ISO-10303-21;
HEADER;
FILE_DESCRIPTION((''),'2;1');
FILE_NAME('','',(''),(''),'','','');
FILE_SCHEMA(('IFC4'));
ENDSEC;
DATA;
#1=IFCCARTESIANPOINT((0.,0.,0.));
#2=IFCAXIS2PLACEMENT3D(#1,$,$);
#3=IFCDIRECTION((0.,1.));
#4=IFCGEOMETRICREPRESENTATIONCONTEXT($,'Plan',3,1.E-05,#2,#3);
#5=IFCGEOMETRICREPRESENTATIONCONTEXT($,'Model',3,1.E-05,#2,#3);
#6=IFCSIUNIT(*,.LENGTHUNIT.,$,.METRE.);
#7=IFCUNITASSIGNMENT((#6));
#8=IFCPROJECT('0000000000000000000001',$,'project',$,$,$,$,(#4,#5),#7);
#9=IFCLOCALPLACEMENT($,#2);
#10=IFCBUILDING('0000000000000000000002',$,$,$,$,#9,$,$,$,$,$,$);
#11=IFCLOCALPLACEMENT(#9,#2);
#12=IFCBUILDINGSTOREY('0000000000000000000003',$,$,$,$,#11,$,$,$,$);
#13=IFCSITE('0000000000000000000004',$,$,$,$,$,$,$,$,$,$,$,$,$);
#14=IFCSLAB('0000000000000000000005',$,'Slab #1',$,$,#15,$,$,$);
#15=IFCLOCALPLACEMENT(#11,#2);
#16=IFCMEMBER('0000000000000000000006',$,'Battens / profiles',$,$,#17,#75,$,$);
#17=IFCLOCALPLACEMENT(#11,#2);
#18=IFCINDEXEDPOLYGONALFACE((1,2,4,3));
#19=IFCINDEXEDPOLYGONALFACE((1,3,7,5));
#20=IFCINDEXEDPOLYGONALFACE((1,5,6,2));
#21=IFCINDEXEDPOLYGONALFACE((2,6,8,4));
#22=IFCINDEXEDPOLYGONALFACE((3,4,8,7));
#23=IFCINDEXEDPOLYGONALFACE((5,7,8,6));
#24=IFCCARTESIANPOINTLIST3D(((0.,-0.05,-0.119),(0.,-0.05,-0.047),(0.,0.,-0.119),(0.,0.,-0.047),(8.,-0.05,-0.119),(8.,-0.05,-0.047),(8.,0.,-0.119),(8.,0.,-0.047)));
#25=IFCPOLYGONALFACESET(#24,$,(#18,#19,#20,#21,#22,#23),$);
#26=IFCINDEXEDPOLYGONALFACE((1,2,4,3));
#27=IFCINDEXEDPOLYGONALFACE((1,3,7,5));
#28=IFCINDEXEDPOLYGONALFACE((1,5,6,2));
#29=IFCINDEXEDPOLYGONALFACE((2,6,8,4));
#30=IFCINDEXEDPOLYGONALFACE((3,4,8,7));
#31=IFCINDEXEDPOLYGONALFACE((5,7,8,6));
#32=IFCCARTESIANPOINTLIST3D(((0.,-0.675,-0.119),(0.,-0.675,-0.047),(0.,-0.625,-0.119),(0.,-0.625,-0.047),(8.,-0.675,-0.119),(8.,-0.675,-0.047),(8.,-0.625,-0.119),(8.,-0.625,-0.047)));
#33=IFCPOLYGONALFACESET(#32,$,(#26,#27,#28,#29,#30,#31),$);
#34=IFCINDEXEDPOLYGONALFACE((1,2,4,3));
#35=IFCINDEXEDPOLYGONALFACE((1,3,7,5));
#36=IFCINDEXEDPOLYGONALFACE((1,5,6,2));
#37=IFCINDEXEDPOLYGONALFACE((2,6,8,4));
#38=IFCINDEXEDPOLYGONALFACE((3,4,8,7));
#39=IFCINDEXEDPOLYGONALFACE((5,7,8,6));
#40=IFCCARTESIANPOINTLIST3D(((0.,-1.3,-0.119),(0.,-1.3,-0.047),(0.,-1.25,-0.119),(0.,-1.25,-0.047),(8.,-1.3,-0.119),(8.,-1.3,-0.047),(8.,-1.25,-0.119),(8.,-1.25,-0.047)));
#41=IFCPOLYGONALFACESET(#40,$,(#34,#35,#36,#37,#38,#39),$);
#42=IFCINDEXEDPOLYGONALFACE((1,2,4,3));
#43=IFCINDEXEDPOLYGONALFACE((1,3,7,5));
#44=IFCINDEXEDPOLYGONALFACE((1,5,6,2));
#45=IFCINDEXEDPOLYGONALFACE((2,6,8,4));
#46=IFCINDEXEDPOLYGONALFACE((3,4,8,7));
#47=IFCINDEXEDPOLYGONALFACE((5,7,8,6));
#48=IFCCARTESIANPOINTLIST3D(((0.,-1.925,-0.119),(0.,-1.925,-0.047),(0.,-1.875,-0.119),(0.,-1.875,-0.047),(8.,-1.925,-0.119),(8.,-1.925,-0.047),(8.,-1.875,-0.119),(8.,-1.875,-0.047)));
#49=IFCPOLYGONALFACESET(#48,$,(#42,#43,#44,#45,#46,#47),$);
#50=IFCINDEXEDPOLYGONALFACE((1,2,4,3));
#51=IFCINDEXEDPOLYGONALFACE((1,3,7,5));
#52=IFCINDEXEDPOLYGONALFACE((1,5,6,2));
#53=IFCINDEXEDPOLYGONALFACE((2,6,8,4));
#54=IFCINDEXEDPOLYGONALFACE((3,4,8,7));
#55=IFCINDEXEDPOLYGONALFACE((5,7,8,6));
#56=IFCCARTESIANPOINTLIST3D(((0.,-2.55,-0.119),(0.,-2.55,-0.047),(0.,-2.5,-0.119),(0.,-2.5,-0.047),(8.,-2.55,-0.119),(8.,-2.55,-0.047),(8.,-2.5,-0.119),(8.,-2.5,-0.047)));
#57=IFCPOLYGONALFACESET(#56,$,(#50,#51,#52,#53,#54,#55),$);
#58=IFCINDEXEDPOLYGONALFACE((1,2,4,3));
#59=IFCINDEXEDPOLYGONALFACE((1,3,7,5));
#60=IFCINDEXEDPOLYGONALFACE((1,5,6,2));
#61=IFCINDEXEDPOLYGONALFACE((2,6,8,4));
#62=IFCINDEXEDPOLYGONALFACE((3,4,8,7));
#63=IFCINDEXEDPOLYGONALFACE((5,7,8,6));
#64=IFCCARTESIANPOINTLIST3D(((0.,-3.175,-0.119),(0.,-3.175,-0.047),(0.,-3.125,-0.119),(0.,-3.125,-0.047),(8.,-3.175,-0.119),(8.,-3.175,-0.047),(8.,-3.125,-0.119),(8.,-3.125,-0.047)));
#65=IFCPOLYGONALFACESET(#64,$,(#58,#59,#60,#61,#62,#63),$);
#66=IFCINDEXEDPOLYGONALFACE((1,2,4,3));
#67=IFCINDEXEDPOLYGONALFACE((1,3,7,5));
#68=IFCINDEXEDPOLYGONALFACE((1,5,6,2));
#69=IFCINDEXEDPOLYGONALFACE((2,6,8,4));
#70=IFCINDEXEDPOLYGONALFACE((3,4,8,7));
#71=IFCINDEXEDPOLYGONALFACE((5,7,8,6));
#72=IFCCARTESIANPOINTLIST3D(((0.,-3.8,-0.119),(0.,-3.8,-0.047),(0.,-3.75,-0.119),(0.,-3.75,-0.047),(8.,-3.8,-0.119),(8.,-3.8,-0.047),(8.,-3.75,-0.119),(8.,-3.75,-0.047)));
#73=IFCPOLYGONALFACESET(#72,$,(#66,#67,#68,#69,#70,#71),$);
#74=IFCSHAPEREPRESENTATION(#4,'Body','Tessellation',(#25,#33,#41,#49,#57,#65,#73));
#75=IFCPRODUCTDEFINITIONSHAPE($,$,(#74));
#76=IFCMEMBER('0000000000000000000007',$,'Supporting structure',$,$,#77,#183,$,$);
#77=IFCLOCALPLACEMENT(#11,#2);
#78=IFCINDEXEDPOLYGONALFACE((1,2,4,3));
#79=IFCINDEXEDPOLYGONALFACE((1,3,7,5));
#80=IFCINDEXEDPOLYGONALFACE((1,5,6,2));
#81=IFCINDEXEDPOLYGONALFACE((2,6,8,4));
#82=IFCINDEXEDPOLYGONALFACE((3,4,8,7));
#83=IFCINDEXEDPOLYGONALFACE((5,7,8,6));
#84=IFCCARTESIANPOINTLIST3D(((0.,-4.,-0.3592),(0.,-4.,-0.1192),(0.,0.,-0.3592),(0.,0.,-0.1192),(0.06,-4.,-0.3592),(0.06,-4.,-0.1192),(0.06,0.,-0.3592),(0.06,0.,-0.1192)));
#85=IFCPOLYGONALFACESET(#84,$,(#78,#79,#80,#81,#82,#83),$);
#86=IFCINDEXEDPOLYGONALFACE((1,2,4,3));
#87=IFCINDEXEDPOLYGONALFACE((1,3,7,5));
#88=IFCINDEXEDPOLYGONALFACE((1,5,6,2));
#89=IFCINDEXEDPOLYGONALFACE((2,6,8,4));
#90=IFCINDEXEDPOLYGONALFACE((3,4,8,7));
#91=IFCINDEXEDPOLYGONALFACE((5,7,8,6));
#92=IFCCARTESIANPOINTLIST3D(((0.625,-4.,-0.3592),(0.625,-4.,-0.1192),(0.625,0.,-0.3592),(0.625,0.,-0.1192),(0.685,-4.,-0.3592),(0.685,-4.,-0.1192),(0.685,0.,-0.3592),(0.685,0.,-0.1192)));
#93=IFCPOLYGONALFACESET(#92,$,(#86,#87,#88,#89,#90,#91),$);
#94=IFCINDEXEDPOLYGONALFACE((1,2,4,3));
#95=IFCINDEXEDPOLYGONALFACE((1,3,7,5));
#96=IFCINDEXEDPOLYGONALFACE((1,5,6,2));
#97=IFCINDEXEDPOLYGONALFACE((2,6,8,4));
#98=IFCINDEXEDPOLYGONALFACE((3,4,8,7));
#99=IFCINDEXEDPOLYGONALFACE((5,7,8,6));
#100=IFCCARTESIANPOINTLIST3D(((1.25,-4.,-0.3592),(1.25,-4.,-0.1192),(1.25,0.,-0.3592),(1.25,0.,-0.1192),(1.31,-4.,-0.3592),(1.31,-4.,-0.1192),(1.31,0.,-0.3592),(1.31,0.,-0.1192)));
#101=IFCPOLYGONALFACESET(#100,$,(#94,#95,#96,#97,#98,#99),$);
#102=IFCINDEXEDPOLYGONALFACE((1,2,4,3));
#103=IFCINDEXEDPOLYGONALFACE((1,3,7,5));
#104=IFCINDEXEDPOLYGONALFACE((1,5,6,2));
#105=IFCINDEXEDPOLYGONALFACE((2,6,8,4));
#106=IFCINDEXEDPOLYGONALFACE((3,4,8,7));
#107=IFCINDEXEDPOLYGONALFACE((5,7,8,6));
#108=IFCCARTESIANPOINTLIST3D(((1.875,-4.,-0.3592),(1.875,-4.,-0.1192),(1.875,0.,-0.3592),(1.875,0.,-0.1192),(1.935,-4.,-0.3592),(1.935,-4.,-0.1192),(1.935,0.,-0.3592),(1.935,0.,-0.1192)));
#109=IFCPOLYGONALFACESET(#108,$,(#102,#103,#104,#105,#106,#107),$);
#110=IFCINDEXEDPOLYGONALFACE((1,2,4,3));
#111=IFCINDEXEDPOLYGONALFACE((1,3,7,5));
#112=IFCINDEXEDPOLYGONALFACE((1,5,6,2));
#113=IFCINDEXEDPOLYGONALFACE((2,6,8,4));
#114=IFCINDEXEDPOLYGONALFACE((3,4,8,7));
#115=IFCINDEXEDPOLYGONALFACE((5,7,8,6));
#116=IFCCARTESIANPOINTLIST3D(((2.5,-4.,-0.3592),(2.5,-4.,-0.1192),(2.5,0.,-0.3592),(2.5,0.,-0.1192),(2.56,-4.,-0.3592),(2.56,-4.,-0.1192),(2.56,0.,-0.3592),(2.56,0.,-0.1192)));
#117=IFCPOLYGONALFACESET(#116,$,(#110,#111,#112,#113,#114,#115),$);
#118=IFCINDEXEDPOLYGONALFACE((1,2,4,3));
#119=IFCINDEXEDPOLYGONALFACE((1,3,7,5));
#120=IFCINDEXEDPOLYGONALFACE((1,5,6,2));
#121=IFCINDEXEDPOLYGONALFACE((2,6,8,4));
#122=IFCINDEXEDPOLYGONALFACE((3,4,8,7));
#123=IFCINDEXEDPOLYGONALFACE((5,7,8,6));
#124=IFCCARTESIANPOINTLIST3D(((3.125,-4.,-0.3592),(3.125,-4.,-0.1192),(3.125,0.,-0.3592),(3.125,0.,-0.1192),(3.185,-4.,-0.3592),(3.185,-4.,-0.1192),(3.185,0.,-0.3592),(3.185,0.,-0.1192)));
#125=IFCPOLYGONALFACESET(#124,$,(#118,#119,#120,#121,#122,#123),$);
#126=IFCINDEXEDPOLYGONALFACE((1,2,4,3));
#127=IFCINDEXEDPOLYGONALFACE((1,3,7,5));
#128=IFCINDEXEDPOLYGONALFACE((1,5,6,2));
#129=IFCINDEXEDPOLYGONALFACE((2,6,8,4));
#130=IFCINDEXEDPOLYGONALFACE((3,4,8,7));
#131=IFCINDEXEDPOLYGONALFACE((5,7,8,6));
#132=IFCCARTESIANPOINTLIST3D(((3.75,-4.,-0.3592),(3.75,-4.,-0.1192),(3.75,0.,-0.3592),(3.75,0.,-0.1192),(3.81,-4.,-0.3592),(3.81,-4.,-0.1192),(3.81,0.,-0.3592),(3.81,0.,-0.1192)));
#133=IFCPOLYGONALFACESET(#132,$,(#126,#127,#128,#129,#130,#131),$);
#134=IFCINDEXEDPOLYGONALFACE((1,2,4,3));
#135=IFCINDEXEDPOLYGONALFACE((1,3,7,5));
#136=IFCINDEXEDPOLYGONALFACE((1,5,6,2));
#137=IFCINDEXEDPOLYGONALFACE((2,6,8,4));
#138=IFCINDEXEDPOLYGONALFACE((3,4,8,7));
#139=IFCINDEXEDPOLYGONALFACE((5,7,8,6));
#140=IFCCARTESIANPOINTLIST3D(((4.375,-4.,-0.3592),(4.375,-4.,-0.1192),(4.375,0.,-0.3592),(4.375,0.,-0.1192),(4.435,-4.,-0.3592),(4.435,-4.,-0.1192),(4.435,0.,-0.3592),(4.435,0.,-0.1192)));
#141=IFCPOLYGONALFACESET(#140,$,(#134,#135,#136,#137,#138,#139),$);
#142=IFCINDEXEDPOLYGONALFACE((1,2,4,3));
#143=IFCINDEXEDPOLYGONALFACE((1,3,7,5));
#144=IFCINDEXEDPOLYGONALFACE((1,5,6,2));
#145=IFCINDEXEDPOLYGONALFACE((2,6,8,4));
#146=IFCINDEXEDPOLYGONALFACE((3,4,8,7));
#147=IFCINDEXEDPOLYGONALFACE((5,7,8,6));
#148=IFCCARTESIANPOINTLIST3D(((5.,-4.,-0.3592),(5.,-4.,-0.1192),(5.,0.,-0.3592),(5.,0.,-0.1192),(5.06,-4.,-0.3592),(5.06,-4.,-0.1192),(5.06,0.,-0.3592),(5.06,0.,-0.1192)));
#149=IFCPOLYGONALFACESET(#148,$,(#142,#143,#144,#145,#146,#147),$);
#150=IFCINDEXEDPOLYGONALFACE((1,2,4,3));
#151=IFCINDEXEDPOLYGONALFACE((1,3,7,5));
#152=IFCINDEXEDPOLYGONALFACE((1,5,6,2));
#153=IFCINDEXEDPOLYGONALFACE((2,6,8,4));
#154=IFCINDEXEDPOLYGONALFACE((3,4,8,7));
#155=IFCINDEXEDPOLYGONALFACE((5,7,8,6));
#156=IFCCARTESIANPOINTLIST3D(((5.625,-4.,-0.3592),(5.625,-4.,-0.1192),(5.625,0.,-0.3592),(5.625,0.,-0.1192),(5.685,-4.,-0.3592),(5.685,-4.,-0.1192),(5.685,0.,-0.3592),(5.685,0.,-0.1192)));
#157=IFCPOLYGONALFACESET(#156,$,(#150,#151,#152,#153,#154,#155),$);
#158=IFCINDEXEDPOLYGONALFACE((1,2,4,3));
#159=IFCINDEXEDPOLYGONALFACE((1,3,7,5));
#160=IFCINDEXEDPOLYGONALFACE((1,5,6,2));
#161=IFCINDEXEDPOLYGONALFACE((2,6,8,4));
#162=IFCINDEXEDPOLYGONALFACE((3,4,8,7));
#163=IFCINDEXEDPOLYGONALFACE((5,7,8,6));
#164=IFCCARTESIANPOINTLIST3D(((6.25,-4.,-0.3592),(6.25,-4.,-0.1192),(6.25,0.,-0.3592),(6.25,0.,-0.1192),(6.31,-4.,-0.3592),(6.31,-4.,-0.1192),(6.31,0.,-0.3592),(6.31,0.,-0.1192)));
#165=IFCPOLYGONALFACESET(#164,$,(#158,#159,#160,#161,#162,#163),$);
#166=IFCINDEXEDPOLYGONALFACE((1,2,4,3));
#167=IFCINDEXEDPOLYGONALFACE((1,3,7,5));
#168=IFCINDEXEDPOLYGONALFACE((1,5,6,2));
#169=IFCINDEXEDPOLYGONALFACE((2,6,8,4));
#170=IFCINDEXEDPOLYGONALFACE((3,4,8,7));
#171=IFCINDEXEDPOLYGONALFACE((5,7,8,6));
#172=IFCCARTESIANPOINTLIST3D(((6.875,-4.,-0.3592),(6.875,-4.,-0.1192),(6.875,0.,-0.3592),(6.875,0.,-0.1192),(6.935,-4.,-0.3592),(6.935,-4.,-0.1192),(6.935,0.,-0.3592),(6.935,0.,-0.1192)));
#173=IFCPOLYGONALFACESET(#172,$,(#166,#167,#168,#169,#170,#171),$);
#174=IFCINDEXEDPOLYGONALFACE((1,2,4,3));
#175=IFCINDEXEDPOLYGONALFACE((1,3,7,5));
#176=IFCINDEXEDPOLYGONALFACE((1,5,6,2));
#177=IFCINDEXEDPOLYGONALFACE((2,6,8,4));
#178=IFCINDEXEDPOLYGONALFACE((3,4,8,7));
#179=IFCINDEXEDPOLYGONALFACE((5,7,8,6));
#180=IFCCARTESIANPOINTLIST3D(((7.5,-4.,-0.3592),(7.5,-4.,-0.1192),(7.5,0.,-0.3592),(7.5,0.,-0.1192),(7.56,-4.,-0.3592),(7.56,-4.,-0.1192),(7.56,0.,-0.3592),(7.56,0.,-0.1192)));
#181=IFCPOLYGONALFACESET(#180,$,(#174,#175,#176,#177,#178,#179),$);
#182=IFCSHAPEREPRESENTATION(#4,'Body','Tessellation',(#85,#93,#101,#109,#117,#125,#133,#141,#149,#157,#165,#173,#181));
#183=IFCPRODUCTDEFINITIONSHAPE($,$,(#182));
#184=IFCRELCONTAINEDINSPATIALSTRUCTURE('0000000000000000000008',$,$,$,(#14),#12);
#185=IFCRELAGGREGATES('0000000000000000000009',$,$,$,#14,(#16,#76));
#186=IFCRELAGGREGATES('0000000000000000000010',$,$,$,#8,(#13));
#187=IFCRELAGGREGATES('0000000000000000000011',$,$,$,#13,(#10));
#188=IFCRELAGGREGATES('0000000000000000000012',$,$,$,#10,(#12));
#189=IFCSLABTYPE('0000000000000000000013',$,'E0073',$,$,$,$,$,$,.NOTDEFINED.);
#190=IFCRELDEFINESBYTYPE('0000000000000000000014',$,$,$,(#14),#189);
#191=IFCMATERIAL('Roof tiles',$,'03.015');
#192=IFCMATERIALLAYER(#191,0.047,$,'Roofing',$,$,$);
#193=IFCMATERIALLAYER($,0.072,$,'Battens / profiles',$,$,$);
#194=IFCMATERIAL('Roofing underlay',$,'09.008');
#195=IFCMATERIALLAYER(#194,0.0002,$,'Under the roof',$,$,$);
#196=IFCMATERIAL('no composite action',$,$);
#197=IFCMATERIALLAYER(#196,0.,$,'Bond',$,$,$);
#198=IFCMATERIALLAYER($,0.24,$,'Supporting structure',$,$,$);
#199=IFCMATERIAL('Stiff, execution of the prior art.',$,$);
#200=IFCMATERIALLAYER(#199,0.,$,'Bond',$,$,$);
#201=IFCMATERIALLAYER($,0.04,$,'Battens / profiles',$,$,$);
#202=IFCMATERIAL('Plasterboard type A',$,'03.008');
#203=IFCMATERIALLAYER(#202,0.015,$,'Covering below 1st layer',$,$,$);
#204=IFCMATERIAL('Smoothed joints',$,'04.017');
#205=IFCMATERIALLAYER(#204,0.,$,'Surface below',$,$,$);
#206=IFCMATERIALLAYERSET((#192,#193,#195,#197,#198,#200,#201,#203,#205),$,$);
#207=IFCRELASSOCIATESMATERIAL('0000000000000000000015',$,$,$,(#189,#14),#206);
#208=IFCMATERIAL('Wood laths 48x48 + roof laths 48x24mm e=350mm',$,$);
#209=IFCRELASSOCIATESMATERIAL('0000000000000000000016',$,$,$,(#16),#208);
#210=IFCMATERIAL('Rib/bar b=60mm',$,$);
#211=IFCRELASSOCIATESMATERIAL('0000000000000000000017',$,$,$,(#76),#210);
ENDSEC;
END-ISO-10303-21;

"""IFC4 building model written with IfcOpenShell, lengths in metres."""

from ifc_helpers import new_model, si_unit, direction, frame, frame_2d, origin, place, context, project, spatial, rectangle, extrude, material, layer, layer_set, type_object, element, aggregate, save


model = new_model("IFC4")

# Units and contexts
plan_context = context("Plan", 3, precision=1e-05, world=origin(), true_north=direction((0.0, 1.0)))
model_context = context("Model", 3, precision=1e-05, world=origin(), true_north=direction((0.0, 1.0)))
ifc_project = project(units=[si_unit("LENGTHUNIT", "METRE")], contexts=[plan_context, model_context])

# Site, building, storey
site = spatial("IfcSite", under=ifc_project)
building_placement = place(None, origin())
building = spatial("IfcBuilding", under=site, at=building_placement)
storey_placement = place(building_placement, origin())
storey = spatial("IfcBuildingStorey", under=building, at=storey_placement)

# Slab, members
ifc_material_1 = material(Name="Roof tiles", Category="03.015")
ifc_layer_1 = layer(ifc_material_1, 0.047, Name="Roofing")
ifc_layer_2 = layer(None, 0.072, Name="Battens / profiles")
ifc_material_2 = material(Name="Roofing underlay", Category="09.008")
ifc_layer_3 = layer(ifc_material_2, 0.0002, Name="Under the roof")
ifc_material_3 = material(Name="no composite action")
ifc_layer_4 = layer(ifc_material_3, 0.0, Name="Bond")
ifc_layer_5 = layer(None, 0.24, Name="Supporting structure")
ifc_material_4 = material(Name="Stiff, execution of the prior art.")
ifc_layer_6 = layer(ifc_material_4, 0.0, Name="Bond")
ifc_layer_7 = layer(None, 0.04, Name="Battens / profiles")
ifc_material_5 = material(Name="Plasterboard type A", Category="03.008")
ifc_layer_8 = layer(ifc_material_5, 0.015, Name="Covering below 1st layer")
ifc_material_6 = material(Name="Smoothed joints", Category="04.017")
ifc_layer_9 = layer(ifc_material_6, 0.0, Name="Surface below")
ifc_layer_set = layer_set([ifc_layer_1, ifc_layer_2, ifc_layer_3, ifc_layer_4, ifc_layer_5, ifc_layer_6, ifc_layer_7, ifc_layer_8, ifc_layer_9])
slab_type = type_object("IfcSlabType", Name="E0073", PredefinedType="NOTDEFINED", material=ifc_layer_set)
slab_placement = place(None, frame((0.0, 0.0, 0.0), z_axis=(0.0, 0.0, -1.0), x_axis=(1.0, 0.0, 0.0)))
slab = element("IfcSlab", 1, at=slab_placement, inside=storey, type_object=slab_type, material=ifc_layer_set, Name="Slab #1")
ifc_material_7 = material(Name="Wood laths 48x48 + roof laths 48x24mm e=350mm")
member_1_placement = place(slab_placement, origin())
member_1 = element("IfcMember", 2, at=member_1_placement, material=ifc_material_7, Name="Battens / profiles", context=plan_context, shape_type="SweptSolid", body=[
    extrude(rectangle(XDim=0.05, YDim=0.072, at=frame_2d((0.025, 0.036), x_axis=(1.0, 0.0))), frame((0.0, 0.0, 0.047), z_axis=(1.0, 0.0, 0.0), x_axis=(0.0, 1.0, 0.0)), (0.0, 0.0, 1.0), 8.0),
    extrude(rectangle(XDim=0.05, YDim=0.072, at=frame_2d((0.025, 0.036), x_axis=(1.0, 0.0))), frame((0.0, 0.625, 0.047), z_axis=(1.0, 0.0, 0.0), x_axis=(0.0, 1.0, 0.0)), (0.0, 0.0, 1.0), 8.0),
    extrude(rectangle(XDim=0.05, YDim=0.072, at=frame_2d((0.025, 0.036), x_axis=(1.0, 0.0))), frame((0.0, 1.25, 0.047), z_axis=(1.0, 0.0, 0.0), x_axis=(0.0, 1.0, 0.0)), (0.0, 0.0, 1.0), 8.0),
    extrude(rectangle(XDim=0.05, YDim=0.072, at=frame_2d((0.025, 0.036), x_axis=(1.0, 0.0))), frame((0.0, 1.875, 0.047), z_axis=(1.0, 0.0, 0.0), x_axis=(0.0, 1.0, 0.0)), (0.0, 0.0, 1.0), 8.0),
    extrude(rectangle(XDim=0.05, YDim=0.072, at=frame_2d((0.025, 0.036), x_axis=(1.0, 0.0))), frame((0.0, 2.5, 0.047), z_axis=(1.0, 0.0, 0.0), x_axis=(0.0, 1.0, 0.0)), (0.0, 0.0, 1.0), 8.0),
    extrude(rectangle(XDim=0.05, YDim=0.072, at=frame_2d((0.025, 0.036), x_axis=(1.0, 0.0))), frame((0.0, 3.125, 0.047), z_axis=(1.0, 0.0, 0.0), x_axis=(0.0, 1.0, 0.0)), (0.0, 0.0, 1.0), 8.0),
    extrude(rectangle(XDim=0.05, YDim=0.072, at=frame_2d((0.025, 0.036), x_axis=(1.0, 0.0))), frame((0.0, 3.75, 0.047), z_axis=(1.0, 0.0, 0.0), x_axis=(0.0, 1.0, 0.0)), (0.0, 0.0, 1.0), 8.0),
])
ifc_material_8 = material(Name="Rib/bar b=60mm")
member_2_placement = place(slab_placement, origin())
member_2 = element("IfcMember", 3, at=member_2_placement, material=ifc_material_8, Name="Supporting structure", context=plan_context, shape_type="SweptSolid", body=[
    extrude(rectangle(XDim=0.06, YDim=0.24, at=frame_2d((0.03, 0.12), x_axis=(1.0, 0.0))), frame((0.0, 4.0, 0.1192), z_axis=(0.0, -1.0, 0.0), x_axis=(1.0, 0.0, 0.0)), (0.0, 0.0, 1.0), 4.0),
    extrude(rectangle(XDim=0.06, YDim=0.24, at=frame_2d((0.03, 0.12), x_axis=(1.0, 0.0))), frame((0.625, 4.0, 0.1192), z_axis=(0.0, -1.0, 0.0), x_axis=(1.0, 0.0, 0.0)), (0.0, 0.0, 1.0), 4.0),
    extrude(rectangle(XDim=0.06, YDim=0.24, at=frame_2d((0.03, 0.12), x_axis=(1.0, 0.0))), frame((1.25, 4.0, 0.1192), z_axis=(0.0, -1.0, 0.0), x_axis=(1.0, 0.0, 0.0)), (0.0, 0.0, 1.0), 4.0),
    extrude(rectangle(XDim=0.06, YDim=0.24, at=frame_2d((0.03, 0.12), x_axis=(1.0, 0.0))), frame((1.875, 4.0, 0.1192), z_axis=(0.0, -1.0, 0.0), x_axis=(1.0, 0.0, 0.0)), (0.0, 0.0, 1.0), 4.0),
    extrude(rectangle(XDim=0.06, YDim=0.24, at=frame_2d((0.03, 0.12), x_axis=(1.0, 0.0))), frame((2.5, 4.0, 0.1192), z_axis=(0.0, -1.0, 0.0), x_axis=(1.0, 0.0, 0.0)), (0.0, 0.0, 1.0), 4.0),
    extrude(rectangle(XDim=0.06, YDim=0.24, at=frame_2d((0.03, 0.12), x_axis=(1.0, 0.0))), frame((3.125, 4.0, 0.1192), z_axis=(0.0, -1.0, 0.0), x_axis=(1.0, 0.0, 0.0)), (0.0, 0.0, 1.0), 4.0),
    extrude(rectangle(XDim=0.06, YDim=0.24, at=frame_2d((0.03, 0.12), x_axis=(1.0, 0.0))), frame((3.75, 4.0, 0.1192), z_axis=(0.0, -1.0, 0.0), x_axis=(1.0, 0.0, 0.0)), (0.0, 0.0, 1.0), 4.0),
    extrude(rectangle(XDim=0.06, YDim=0.24, at=frame_2d((0.03, 0.12), x_axis=(1.0, 0.0))), frame((4.375, 4.0, 0.1192), z_axis=(0.0, -1.0, 0.0), x_axis=(1.0, 0.0, 0.0)), (0.0, 0.0, 1.0), 4.0),
    extrude(rectangle(XDim=0.06, YDim=0.24, at=frame_2d((0.03, 0.12), x_axis=(1.0, 0.0))), frame((5.0, 4.0, 0.1192), z_axis=(0.0, -1.0, 0.0), x_axis=(1.0, 0.0, 0.0)), (0.0, 0.0, 1.0), 4.0),
    extrude(rectangle(XDim=0.06, YDim=0.24, at=frame_2d((0.03, 0.12), x_axis=(1.0, 0.0))), frame((5.625, 4.0, 0.1192), z_axis=(0.0, -1.0, 0.0), x_axis=(1.0, 0.0, 0.0)), (0.0, 0.0, 1.0), 4.0),
    extrude(rectangle(XDim=0.06, YDim=0.24, at=frame_2d((0.03, 0.12), x_axis=(1.0, 0.0))), frame((6.25, 4.0, 0.1192), z_axis=(0.0, -1.0, 0.0), x_axis=(1.0, 0.0, 0.0)), (0.0, 0.0, 1.0), 4.0),
    extrude(rectangle(XDim=0.06, YDim=0.24, at=frame_2d((0.03, 0.12), x_axis=(1.0, 0.0))), frame((6.875, 4.0, 0.1192), z_axis=(0.0, -1.0, 0.0), x_axis=(1.0, 0.0, 0.0)), (0.0, 0.0, 1.0), 4.0),
    extrude(rectangle(XDim=0.06, YDim=0.24, at=frame_2d((0.03, 0.12), x_axis=(1.0, 0.0))), frame((7.5, 4.0, 0.1192), z_axis=(0.0, -1.0, 0.0), x_axis=(1.0, 0.0, 0.0)), (0.0, 0.0, 1.0), 4.0),
])
aggregate(slab, [member_1, member_2])

save(model, "model.ifc")
